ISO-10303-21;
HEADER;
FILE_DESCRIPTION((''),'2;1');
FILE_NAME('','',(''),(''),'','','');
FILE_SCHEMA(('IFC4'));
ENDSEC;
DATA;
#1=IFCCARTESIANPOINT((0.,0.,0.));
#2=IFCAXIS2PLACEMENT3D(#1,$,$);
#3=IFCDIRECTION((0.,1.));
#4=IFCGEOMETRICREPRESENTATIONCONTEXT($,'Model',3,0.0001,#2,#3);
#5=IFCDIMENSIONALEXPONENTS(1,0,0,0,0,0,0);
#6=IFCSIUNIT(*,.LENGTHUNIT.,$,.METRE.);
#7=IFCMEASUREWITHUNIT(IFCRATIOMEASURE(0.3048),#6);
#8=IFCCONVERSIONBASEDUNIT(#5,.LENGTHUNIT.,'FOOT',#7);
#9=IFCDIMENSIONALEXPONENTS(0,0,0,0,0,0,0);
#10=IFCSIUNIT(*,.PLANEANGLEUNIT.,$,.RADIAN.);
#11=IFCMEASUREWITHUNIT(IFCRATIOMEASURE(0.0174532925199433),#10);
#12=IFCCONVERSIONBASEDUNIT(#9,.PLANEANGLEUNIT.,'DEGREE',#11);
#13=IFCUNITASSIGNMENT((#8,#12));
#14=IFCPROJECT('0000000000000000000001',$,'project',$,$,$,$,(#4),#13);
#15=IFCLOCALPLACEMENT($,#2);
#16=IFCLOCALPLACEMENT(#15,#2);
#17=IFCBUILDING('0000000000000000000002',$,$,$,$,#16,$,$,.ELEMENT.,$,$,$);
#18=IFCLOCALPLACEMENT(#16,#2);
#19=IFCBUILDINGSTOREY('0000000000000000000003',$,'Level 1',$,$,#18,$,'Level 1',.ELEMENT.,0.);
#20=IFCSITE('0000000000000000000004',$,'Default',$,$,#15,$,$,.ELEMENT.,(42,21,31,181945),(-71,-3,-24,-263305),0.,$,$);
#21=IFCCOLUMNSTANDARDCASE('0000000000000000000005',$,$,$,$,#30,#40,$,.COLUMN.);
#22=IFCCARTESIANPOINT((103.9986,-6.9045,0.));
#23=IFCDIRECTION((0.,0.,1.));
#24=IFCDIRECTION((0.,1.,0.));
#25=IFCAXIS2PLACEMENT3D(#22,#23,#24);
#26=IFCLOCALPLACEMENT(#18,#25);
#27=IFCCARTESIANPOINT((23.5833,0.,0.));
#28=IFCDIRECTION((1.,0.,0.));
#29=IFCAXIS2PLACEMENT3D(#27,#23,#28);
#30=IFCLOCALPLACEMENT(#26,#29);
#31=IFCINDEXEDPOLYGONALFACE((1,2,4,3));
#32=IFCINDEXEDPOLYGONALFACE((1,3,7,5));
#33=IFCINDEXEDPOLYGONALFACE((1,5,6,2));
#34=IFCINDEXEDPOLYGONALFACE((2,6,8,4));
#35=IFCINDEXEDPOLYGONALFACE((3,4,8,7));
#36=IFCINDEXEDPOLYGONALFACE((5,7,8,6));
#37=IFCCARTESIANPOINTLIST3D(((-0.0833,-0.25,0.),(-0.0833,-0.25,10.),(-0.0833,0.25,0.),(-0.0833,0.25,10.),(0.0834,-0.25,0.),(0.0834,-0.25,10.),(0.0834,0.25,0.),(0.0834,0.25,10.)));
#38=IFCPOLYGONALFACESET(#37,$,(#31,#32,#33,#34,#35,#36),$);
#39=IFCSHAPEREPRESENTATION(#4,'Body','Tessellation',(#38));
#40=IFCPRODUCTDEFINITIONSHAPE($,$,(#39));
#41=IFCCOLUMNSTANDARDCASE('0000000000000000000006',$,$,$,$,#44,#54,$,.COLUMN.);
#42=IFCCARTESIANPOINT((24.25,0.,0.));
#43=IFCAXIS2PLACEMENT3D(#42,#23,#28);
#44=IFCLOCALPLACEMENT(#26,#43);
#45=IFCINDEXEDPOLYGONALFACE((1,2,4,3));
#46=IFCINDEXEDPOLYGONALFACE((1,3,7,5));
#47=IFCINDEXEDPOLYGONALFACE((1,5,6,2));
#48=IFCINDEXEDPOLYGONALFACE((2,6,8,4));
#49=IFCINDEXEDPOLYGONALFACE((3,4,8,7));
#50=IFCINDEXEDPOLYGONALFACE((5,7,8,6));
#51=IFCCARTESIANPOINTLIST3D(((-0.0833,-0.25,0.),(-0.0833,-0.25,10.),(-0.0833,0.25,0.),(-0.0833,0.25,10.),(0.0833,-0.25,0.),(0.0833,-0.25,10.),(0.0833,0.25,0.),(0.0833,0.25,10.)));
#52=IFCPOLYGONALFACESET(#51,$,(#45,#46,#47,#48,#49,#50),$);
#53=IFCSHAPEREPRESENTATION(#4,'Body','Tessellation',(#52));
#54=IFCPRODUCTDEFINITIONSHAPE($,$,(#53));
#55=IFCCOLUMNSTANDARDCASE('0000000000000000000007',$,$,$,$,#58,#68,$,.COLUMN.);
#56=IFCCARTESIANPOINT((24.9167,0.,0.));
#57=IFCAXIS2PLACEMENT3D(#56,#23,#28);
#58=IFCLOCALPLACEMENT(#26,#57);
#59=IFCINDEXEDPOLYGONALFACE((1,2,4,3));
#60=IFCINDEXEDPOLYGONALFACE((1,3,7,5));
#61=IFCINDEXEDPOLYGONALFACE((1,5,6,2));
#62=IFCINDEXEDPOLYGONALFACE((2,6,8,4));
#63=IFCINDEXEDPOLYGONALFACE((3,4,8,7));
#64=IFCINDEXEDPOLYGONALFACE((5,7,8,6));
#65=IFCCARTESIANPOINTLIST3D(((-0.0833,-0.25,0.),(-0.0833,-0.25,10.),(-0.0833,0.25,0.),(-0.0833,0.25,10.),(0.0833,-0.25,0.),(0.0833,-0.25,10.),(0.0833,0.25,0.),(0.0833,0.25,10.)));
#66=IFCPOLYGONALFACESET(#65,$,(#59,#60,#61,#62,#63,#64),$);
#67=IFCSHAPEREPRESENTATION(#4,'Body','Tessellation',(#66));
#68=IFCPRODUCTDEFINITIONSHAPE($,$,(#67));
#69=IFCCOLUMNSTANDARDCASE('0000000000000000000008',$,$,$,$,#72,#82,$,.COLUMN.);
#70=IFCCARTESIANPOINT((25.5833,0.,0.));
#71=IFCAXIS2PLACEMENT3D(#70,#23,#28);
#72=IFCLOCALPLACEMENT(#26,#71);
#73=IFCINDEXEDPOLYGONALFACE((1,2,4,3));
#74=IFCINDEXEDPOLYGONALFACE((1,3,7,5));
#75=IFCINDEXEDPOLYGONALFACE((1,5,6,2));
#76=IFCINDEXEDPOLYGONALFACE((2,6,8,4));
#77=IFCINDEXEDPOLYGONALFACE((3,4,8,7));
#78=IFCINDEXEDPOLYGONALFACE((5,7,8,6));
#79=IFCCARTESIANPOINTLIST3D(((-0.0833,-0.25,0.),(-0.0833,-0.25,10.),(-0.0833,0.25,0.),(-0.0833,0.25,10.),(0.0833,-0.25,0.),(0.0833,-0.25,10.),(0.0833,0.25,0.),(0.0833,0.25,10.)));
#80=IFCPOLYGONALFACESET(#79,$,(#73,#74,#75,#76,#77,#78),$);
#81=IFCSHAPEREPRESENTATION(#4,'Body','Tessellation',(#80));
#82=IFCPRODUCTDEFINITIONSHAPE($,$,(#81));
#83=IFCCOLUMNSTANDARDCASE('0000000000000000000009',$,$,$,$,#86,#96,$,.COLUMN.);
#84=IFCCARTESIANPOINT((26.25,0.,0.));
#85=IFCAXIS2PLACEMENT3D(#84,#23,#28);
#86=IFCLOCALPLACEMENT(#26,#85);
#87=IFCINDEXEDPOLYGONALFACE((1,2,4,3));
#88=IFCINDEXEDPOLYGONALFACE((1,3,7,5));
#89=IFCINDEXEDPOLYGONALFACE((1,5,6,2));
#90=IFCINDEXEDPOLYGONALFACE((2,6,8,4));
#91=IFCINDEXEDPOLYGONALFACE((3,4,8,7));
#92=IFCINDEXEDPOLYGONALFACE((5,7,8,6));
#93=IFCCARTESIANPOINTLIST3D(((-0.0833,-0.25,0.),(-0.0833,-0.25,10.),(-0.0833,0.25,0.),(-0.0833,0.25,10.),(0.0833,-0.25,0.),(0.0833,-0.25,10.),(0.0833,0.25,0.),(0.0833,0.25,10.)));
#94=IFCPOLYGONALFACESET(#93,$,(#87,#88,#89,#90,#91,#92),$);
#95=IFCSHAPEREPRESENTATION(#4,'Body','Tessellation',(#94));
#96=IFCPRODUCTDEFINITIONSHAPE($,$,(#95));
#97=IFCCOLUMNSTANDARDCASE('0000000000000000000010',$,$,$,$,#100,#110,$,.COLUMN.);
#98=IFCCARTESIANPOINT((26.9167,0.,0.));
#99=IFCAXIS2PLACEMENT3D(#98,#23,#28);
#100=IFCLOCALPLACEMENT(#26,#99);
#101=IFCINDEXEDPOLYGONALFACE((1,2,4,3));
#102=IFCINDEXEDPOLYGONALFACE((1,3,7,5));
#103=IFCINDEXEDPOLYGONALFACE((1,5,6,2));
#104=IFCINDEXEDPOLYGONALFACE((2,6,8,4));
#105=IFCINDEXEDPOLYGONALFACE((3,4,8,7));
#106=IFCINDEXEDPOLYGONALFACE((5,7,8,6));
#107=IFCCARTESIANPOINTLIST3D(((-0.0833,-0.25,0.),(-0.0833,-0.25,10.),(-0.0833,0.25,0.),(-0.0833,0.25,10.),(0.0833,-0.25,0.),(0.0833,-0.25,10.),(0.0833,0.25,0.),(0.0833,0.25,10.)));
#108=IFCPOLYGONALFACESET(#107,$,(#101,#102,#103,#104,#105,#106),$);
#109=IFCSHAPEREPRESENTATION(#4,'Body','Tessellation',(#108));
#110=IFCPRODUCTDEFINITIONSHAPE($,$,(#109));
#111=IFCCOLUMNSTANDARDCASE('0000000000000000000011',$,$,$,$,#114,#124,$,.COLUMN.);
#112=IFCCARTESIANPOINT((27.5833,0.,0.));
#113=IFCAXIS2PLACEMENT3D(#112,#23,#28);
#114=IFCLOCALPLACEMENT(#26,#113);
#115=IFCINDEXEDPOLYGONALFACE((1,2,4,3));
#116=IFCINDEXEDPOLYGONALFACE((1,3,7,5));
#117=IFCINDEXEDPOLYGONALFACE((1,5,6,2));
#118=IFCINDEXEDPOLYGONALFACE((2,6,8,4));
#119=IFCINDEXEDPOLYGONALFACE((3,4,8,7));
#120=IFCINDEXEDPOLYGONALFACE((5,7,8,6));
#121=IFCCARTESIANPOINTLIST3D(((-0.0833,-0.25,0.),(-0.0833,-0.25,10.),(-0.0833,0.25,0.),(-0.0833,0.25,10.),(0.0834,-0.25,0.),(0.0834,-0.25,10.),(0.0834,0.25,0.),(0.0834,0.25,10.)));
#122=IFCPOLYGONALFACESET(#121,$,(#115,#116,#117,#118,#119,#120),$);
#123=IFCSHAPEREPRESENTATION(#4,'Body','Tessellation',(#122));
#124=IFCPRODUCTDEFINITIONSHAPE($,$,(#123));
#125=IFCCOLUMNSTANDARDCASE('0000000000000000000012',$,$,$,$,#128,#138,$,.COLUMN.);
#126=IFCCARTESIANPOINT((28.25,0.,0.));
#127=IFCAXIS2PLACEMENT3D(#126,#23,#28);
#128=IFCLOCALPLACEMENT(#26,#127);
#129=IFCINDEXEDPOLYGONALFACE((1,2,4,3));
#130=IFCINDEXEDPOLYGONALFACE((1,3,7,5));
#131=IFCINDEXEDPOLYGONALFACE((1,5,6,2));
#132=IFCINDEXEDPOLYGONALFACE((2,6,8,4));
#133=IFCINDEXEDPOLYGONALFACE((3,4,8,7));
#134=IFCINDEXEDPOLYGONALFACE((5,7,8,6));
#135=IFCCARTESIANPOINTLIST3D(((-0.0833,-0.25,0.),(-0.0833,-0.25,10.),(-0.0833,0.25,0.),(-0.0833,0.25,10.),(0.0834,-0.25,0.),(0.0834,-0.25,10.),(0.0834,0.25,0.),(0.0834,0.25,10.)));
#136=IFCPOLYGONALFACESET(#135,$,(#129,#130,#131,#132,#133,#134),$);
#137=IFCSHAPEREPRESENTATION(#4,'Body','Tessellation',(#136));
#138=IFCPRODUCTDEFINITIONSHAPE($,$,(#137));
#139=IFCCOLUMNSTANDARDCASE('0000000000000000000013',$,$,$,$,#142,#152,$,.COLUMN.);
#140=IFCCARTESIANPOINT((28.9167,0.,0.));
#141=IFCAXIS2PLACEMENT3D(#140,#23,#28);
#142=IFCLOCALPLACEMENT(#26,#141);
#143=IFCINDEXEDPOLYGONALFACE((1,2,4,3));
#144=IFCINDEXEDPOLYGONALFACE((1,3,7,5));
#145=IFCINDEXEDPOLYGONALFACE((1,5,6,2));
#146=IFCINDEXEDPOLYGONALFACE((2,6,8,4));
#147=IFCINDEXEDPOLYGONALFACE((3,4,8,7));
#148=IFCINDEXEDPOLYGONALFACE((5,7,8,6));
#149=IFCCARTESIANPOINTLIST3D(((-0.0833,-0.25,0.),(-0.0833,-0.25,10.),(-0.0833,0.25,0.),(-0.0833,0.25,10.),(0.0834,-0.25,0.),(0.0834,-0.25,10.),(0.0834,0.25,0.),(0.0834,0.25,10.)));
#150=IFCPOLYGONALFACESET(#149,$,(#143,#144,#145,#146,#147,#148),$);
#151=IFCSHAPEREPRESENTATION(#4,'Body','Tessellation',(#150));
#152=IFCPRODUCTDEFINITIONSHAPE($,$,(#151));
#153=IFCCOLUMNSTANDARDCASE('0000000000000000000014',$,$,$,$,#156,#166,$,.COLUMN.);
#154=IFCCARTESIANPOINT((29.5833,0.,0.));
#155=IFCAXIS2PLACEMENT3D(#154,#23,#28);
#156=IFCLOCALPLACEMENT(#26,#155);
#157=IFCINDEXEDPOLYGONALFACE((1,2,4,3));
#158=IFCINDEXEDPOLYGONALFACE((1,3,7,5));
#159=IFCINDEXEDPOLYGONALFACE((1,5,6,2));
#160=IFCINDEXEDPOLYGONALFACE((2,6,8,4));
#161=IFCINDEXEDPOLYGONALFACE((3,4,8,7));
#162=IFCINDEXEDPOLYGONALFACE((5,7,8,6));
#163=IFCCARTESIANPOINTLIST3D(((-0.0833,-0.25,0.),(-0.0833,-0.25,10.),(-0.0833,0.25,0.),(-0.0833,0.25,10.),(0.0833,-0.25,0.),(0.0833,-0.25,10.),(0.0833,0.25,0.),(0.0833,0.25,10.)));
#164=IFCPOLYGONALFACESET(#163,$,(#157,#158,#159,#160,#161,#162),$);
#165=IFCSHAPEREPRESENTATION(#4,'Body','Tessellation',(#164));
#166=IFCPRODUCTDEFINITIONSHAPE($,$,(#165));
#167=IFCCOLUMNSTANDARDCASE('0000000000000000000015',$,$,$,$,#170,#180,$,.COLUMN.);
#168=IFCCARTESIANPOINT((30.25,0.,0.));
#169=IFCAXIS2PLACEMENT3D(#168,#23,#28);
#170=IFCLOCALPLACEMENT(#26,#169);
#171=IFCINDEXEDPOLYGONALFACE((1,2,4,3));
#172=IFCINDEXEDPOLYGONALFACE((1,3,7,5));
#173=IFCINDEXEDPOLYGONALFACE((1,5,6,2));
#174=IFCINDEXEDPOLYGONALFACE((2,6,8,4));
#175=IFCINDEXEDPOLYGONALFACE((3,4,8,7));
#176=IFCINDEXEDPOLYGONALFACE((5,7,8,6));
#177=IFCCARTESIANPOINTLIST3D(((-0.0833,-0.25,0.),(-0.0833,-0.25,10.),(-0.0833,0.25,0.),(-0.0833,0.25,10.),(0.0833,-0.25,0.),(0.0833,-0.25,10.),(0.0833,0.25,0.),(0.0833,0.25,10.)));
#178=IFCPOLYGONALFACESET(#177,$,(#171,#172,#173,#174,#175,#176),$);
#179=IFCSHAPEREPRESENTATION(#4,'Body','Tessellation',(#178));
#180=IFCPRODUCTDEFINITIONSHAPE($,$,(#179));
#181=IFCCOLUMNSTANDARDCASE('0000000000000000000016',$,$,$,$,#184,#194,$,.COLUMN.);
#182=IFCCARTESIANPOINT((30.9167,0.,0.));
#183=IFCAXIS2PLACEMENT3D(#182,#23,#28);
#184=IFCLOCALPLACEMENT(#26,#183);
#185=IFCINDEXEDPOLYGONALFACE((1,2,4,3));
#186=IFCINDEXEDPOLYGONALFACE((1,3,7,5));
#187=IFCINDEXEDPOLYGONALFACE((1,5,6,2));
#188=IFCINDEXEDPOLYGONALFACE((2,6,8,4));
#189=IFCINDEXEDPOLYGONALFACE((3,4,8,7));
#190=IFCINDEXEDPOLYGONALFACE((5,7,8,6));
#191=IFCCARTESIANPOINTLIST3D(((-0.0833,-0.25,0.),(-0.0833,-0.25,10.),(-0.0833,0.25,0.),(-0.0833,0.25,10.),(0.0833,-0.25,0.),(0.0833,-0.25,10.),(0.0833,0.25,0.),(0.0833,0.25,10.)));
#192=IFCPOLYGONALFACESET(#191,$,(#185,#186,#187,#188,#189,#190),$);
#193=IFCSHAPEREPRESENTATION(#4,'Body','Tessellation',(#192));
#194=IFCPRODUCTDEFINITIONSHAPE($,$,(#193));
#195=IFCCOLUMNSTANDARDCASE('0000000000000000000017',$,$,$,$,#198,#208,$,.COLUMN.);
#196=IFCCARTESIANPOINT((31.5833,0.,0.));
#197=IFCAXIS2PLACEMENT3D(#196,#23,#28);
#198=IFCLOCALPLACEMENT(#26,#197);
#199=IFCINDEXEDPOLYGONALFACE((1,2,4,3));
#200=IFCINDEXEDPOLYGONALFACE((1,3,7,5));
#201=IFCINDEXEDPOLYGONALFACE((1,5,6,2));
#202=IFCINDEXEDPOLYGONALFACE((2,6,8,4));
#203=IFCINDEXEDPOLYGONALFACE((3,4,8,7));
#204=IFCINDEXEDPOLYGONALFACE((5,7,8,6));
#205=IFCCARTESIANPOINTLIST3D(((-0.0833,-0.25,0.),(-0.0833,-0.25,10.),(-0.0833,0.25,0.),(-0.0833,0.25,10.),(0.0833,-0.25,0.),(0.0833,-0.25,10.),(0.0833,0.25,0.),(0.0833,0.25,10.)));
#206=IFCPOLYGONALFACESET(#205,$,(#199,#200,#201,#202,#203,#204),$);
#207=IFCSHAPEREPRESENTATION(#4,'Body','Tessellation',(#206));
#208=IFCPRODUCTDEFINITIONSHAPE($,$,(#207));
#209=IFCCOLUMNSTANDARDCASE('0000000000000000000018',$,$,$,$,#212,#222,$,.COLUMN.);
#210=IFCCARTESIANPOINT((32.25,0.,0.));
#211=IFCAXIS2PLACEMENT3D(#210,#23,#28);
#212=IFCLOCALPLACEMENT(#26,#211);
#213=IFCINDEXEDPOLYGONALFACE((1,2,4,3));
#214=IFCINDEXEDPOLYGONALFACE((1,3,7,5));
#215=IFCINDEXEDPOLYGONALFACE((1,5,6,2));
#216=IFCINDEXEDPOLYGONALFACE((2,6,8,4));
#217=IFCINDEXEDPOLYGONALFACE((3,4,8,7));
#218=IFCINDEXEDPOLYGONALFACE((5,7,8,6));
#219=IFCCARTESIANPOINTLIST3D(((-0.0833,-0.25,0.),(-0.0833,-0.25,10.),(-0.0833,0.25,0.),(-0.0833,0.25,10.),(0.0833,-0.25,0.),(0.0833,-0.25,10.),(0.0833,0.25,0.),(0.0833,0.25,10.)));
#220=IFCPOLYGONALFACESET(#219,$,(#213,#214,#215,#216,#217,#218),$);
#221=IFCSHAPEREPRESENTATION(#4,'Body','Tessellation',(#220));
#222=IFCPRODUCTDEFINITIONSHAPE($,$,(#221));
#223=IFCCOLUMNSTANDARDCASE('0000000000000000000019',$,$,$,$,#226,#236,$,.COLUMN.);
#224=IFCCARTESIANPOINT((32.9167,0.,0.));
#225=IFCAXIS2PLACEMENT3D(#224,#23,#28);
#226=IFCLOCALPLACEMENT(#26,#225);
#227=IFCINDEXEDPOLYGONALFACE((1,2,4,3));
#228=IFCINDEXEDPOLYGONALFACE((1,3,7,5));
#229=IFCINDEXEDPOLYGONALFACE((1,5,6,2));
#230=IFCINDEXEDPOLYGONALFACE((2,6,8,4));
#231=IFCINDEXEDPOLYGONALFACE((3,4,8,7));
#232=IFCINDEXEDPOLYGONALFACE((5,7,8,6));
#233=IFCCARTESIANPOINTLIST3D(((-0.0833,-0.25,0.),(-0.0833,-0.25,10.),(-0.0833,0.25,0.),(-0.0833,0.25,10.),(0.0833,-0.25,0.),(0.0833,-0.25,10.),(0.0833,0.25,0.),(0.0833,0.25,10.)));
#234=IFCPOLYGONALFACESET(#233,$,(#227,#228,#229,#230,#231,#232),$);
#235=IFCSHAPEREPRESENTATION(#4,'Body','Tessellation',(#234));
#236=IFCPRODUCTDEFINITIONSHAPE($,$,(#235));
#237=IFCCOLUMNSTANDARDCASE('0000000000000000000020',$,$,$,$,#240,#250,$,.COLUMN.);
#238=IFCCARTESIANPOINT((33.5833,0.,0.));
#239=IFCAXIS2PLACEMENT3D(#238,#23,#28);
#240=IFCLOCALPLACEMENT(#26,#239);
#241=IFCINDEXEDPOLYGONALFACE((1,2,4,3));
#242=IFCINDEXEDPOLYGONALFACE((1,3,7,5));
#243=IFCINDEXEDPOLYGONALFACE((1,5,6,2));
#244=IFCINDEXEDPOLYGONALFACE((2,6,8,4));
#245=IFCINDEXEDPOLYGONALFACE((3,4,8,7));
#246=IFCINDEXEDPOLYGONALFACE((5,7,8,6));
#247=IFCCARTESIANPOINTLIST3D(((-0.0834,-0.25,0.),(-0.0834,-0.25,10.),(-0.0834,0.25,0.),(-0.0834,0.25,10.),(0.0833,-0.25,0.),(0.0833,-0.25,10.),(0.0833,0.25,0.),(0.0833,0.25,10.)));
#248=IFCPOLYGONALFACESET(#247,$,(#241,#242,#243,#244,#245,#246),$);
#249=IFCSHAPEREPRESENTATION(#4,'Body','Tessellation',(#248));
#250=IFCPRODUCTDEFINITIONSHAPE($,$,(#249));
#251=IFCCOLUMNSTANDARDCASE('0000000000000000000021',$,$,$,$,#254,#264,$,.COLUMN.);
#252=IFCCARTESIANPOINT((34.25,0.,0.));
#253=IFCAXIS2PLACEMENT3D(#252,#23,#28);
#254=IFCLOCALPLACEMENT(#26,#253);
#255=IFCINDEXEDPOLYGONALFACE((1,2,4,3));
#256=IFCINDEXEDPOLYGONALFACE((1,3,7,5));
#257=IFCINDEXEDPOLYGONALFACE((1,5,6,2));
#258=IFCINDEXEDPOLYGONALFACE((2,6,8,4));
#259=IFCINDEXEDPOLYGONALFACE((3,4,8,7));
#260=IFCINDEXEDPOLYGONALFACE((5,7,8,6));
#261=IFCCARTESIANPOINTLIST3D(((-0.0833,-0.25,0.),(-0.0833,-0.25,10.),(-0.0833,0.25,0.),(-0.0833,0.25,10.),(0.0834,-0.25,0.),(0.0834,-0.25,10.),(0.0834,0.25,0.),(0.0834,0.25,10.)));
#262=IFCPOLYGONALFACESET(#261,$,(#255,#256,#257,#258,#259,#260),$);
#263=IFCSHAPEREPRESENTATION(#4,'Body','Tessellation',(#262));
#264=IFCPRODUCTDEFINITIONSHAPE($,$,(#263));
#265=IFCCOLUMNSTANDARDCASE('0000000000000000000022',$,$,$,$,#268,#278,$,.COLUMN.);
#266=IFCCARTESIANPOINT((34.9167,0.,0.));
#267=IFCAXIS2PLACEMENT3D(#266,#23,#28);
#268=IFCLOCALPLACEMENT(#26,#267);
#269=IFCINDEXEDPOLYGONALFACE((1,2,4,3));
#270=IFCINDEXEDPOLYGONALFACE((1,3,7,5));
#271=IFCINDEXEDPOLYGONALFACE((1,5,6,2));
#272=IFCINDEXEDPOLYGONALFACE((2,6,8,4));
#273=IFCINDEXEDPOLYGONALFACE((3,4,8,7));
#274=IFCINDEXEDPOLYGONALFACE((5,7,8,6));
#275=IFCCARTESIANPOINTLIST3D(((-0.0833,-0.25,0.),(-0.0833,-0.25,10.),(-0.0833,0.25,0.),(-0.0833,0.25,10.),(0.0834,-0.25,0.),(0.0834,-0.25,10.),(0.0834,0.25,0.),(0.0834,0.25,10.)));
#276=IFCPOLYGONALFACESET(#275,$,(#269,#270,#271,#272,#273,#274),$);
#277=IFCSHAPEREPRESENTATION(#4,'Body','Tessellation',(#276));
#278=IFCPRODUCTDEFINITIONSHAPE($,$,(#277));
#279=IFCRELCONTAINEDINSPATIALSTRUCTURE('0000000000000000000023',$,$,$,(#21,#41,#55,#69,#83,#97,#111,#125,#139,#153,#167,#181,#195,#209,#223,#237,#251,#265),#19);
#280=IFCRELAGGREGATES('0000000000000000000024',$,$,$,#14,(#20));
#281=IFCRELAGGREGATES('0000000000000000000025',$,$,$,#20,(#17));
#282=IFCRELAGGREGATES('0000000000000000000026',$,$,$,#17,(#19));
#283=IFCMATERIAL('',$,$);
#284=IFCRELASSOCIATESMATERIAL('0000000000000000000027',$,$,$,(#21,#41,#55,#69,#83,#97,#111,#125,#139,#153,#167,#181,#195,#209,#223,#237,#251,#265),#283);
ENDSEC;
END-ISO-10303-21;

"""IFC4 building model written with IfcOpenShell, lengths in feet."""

from ifc_helpers import new_model, entity, si_unit, converted_unit, direction, frame, origin, place, context, project, spatial, rectangle, extrude, material, element, save


model = new_model("IFC4")

# Units and contexts
model_context = context("Model", 3, precision=0.0001, world=origin(), true_north=direction((0.0, 1.0)))
ifc_project = project(units=[converted_unit("LENGTHUNIT", "FOOT", entity("IfcRatioMeasure", 0.3048), si_unit("LENGTHUNIT", "METRE"), dimensions=[1, 0, 0, 0, 0, 0, 0]), converted_unit("PLANEANGLEUNIT", "DEGREE", entity("IfcRatioMeasure", 0.0174532925199433), si_unit("PLANEANGLEUNIT", "RADIAN"), dimensions=[0, 0, 0, 0, 0, 0, 0])], contexts=[model_context])

# Site, building, storey
site_placement = place(None, origin())
site = spatial("IfcSite", under=ifc_project, at=site_placement, Name="Default", CompositionType="ELEMENT", RefLatitude=(42, 21, 31, 181945), RefLongitude=(-71, -3, -24, -263305), RefElevation=0.0)
building_placement = place(site_placement, origin())
building = spatial("IfcBuilding", under=site, at=building_placement, CompositionType="ELEMENT")
storey_placement = place(building_placement, origin())
storey = spatial("IfcBuildingStorey", under=building, at=storey_placement, Name="Level 1", LongName="Level 1", CompositionType="ELEMENT", Elevation=0.0)

# Columns
ifc_material_1 = material(Name="")
placement_1 = place(storey_placement, frame((103.9986, -6.9045, 0.0), z_axis=(0.0, 0.0, 1.0), x_axis=(0.0, 1.0, 0.0)))
for number, where, z_axis, x_axis in (
    (1, (23.5833, 0.0, 0.0), (0.0, 0.0, 1.0), (1.0, 0.0, 0.0)),
    (2, (24.25, 0.0, 0.0), (0.0, 0.0, 1.0), (1.0, 0.0, 0.0)),
    (3, (24.9167, 0.0, 0.0), (0.0, 0.0, 1.0), (1.0, 0.0, 0.0)),
    (4, (25.5833, 0.0, 0.0), (0.0, 0.0, 1.0), (1.0, 0.0, 0.0)),
    (5, (26.25, 0.0, 0.0), (0.0, 0.0, 1.0), (1.0, 0.0, 0.0)),
    (6, (26.9167, 0.0, 0.0), (0.0, 0.0, 1.0), (1.0, 0.0, 0.0)),
    (7, (27.5833, 0.0, 0.0), (0.0, 0.0, 1.0), (1.0, 0.0, 0.0)),
    (8, (28.25, 0.0, 0.0), (0.0, 0.0, 1.0), (1.0, 0.0, 0.0)),
    (9, (28.9167, 0.0, 0.0), (0.0, 0.0, 1.0), (1.0, 0.0, 0.0)),
    (10, (29.5833, 0.0, 0.0), (0.0, 0.0, 1.0), (1.0, 0.0, 0.0)),
    (11, (30.25, 0.0, 0.0), (0.0, 0.0, 1.0), (1.0, 0.0, 0.0)),
    (12, (30.9167, 0.0, 0.0), (0.0, 0.0, 1.0), (1.0, 0.0, 0.0)),
    (13, (31.5833, 0.0, 0.0), (0.0, 0.0, 1.0), (1.0, 0.0, 0.0)),
    (14, (32.25, 0.0, 0.0), (0.0, 0.0, 1.0), (1.0, 0.0, 0.0)),
    (15, (32.9167, 0.0, 0.0), (0.0, 0.0, 1.0), (1.0, 0.0, 0.0)),
    (16, (33.5833, 0.0, 0.0), (0.0, 0.0, 1.0), (1.0, 0.0, 0.0)),
    (17, (34.25, 0.0, 0.0), (0.0, 0.0, 1.0), (1.0, 0.0, 0.0)),
    (18, (34.9167, 0.0, 0.0), (0.0, 0.0, 1.0), (1.0, 0.0, 0.0)),
):
    element("IfcColumnStandardCase", number, at=place(placement_1, frame(where, z_axis=z_axis, x_axis=x_axis)), inside=storey, material=ifc_material_1, PredefinedType="COLUMN", context=model_context, shape_type="SweptSolid", body=[
        extrude(rectangle(XDim=0.1667, YDim=0.5), origin(), (0.0, 0.0, 1.0), 10.0),
    ])

save(model, "model.ifc")
